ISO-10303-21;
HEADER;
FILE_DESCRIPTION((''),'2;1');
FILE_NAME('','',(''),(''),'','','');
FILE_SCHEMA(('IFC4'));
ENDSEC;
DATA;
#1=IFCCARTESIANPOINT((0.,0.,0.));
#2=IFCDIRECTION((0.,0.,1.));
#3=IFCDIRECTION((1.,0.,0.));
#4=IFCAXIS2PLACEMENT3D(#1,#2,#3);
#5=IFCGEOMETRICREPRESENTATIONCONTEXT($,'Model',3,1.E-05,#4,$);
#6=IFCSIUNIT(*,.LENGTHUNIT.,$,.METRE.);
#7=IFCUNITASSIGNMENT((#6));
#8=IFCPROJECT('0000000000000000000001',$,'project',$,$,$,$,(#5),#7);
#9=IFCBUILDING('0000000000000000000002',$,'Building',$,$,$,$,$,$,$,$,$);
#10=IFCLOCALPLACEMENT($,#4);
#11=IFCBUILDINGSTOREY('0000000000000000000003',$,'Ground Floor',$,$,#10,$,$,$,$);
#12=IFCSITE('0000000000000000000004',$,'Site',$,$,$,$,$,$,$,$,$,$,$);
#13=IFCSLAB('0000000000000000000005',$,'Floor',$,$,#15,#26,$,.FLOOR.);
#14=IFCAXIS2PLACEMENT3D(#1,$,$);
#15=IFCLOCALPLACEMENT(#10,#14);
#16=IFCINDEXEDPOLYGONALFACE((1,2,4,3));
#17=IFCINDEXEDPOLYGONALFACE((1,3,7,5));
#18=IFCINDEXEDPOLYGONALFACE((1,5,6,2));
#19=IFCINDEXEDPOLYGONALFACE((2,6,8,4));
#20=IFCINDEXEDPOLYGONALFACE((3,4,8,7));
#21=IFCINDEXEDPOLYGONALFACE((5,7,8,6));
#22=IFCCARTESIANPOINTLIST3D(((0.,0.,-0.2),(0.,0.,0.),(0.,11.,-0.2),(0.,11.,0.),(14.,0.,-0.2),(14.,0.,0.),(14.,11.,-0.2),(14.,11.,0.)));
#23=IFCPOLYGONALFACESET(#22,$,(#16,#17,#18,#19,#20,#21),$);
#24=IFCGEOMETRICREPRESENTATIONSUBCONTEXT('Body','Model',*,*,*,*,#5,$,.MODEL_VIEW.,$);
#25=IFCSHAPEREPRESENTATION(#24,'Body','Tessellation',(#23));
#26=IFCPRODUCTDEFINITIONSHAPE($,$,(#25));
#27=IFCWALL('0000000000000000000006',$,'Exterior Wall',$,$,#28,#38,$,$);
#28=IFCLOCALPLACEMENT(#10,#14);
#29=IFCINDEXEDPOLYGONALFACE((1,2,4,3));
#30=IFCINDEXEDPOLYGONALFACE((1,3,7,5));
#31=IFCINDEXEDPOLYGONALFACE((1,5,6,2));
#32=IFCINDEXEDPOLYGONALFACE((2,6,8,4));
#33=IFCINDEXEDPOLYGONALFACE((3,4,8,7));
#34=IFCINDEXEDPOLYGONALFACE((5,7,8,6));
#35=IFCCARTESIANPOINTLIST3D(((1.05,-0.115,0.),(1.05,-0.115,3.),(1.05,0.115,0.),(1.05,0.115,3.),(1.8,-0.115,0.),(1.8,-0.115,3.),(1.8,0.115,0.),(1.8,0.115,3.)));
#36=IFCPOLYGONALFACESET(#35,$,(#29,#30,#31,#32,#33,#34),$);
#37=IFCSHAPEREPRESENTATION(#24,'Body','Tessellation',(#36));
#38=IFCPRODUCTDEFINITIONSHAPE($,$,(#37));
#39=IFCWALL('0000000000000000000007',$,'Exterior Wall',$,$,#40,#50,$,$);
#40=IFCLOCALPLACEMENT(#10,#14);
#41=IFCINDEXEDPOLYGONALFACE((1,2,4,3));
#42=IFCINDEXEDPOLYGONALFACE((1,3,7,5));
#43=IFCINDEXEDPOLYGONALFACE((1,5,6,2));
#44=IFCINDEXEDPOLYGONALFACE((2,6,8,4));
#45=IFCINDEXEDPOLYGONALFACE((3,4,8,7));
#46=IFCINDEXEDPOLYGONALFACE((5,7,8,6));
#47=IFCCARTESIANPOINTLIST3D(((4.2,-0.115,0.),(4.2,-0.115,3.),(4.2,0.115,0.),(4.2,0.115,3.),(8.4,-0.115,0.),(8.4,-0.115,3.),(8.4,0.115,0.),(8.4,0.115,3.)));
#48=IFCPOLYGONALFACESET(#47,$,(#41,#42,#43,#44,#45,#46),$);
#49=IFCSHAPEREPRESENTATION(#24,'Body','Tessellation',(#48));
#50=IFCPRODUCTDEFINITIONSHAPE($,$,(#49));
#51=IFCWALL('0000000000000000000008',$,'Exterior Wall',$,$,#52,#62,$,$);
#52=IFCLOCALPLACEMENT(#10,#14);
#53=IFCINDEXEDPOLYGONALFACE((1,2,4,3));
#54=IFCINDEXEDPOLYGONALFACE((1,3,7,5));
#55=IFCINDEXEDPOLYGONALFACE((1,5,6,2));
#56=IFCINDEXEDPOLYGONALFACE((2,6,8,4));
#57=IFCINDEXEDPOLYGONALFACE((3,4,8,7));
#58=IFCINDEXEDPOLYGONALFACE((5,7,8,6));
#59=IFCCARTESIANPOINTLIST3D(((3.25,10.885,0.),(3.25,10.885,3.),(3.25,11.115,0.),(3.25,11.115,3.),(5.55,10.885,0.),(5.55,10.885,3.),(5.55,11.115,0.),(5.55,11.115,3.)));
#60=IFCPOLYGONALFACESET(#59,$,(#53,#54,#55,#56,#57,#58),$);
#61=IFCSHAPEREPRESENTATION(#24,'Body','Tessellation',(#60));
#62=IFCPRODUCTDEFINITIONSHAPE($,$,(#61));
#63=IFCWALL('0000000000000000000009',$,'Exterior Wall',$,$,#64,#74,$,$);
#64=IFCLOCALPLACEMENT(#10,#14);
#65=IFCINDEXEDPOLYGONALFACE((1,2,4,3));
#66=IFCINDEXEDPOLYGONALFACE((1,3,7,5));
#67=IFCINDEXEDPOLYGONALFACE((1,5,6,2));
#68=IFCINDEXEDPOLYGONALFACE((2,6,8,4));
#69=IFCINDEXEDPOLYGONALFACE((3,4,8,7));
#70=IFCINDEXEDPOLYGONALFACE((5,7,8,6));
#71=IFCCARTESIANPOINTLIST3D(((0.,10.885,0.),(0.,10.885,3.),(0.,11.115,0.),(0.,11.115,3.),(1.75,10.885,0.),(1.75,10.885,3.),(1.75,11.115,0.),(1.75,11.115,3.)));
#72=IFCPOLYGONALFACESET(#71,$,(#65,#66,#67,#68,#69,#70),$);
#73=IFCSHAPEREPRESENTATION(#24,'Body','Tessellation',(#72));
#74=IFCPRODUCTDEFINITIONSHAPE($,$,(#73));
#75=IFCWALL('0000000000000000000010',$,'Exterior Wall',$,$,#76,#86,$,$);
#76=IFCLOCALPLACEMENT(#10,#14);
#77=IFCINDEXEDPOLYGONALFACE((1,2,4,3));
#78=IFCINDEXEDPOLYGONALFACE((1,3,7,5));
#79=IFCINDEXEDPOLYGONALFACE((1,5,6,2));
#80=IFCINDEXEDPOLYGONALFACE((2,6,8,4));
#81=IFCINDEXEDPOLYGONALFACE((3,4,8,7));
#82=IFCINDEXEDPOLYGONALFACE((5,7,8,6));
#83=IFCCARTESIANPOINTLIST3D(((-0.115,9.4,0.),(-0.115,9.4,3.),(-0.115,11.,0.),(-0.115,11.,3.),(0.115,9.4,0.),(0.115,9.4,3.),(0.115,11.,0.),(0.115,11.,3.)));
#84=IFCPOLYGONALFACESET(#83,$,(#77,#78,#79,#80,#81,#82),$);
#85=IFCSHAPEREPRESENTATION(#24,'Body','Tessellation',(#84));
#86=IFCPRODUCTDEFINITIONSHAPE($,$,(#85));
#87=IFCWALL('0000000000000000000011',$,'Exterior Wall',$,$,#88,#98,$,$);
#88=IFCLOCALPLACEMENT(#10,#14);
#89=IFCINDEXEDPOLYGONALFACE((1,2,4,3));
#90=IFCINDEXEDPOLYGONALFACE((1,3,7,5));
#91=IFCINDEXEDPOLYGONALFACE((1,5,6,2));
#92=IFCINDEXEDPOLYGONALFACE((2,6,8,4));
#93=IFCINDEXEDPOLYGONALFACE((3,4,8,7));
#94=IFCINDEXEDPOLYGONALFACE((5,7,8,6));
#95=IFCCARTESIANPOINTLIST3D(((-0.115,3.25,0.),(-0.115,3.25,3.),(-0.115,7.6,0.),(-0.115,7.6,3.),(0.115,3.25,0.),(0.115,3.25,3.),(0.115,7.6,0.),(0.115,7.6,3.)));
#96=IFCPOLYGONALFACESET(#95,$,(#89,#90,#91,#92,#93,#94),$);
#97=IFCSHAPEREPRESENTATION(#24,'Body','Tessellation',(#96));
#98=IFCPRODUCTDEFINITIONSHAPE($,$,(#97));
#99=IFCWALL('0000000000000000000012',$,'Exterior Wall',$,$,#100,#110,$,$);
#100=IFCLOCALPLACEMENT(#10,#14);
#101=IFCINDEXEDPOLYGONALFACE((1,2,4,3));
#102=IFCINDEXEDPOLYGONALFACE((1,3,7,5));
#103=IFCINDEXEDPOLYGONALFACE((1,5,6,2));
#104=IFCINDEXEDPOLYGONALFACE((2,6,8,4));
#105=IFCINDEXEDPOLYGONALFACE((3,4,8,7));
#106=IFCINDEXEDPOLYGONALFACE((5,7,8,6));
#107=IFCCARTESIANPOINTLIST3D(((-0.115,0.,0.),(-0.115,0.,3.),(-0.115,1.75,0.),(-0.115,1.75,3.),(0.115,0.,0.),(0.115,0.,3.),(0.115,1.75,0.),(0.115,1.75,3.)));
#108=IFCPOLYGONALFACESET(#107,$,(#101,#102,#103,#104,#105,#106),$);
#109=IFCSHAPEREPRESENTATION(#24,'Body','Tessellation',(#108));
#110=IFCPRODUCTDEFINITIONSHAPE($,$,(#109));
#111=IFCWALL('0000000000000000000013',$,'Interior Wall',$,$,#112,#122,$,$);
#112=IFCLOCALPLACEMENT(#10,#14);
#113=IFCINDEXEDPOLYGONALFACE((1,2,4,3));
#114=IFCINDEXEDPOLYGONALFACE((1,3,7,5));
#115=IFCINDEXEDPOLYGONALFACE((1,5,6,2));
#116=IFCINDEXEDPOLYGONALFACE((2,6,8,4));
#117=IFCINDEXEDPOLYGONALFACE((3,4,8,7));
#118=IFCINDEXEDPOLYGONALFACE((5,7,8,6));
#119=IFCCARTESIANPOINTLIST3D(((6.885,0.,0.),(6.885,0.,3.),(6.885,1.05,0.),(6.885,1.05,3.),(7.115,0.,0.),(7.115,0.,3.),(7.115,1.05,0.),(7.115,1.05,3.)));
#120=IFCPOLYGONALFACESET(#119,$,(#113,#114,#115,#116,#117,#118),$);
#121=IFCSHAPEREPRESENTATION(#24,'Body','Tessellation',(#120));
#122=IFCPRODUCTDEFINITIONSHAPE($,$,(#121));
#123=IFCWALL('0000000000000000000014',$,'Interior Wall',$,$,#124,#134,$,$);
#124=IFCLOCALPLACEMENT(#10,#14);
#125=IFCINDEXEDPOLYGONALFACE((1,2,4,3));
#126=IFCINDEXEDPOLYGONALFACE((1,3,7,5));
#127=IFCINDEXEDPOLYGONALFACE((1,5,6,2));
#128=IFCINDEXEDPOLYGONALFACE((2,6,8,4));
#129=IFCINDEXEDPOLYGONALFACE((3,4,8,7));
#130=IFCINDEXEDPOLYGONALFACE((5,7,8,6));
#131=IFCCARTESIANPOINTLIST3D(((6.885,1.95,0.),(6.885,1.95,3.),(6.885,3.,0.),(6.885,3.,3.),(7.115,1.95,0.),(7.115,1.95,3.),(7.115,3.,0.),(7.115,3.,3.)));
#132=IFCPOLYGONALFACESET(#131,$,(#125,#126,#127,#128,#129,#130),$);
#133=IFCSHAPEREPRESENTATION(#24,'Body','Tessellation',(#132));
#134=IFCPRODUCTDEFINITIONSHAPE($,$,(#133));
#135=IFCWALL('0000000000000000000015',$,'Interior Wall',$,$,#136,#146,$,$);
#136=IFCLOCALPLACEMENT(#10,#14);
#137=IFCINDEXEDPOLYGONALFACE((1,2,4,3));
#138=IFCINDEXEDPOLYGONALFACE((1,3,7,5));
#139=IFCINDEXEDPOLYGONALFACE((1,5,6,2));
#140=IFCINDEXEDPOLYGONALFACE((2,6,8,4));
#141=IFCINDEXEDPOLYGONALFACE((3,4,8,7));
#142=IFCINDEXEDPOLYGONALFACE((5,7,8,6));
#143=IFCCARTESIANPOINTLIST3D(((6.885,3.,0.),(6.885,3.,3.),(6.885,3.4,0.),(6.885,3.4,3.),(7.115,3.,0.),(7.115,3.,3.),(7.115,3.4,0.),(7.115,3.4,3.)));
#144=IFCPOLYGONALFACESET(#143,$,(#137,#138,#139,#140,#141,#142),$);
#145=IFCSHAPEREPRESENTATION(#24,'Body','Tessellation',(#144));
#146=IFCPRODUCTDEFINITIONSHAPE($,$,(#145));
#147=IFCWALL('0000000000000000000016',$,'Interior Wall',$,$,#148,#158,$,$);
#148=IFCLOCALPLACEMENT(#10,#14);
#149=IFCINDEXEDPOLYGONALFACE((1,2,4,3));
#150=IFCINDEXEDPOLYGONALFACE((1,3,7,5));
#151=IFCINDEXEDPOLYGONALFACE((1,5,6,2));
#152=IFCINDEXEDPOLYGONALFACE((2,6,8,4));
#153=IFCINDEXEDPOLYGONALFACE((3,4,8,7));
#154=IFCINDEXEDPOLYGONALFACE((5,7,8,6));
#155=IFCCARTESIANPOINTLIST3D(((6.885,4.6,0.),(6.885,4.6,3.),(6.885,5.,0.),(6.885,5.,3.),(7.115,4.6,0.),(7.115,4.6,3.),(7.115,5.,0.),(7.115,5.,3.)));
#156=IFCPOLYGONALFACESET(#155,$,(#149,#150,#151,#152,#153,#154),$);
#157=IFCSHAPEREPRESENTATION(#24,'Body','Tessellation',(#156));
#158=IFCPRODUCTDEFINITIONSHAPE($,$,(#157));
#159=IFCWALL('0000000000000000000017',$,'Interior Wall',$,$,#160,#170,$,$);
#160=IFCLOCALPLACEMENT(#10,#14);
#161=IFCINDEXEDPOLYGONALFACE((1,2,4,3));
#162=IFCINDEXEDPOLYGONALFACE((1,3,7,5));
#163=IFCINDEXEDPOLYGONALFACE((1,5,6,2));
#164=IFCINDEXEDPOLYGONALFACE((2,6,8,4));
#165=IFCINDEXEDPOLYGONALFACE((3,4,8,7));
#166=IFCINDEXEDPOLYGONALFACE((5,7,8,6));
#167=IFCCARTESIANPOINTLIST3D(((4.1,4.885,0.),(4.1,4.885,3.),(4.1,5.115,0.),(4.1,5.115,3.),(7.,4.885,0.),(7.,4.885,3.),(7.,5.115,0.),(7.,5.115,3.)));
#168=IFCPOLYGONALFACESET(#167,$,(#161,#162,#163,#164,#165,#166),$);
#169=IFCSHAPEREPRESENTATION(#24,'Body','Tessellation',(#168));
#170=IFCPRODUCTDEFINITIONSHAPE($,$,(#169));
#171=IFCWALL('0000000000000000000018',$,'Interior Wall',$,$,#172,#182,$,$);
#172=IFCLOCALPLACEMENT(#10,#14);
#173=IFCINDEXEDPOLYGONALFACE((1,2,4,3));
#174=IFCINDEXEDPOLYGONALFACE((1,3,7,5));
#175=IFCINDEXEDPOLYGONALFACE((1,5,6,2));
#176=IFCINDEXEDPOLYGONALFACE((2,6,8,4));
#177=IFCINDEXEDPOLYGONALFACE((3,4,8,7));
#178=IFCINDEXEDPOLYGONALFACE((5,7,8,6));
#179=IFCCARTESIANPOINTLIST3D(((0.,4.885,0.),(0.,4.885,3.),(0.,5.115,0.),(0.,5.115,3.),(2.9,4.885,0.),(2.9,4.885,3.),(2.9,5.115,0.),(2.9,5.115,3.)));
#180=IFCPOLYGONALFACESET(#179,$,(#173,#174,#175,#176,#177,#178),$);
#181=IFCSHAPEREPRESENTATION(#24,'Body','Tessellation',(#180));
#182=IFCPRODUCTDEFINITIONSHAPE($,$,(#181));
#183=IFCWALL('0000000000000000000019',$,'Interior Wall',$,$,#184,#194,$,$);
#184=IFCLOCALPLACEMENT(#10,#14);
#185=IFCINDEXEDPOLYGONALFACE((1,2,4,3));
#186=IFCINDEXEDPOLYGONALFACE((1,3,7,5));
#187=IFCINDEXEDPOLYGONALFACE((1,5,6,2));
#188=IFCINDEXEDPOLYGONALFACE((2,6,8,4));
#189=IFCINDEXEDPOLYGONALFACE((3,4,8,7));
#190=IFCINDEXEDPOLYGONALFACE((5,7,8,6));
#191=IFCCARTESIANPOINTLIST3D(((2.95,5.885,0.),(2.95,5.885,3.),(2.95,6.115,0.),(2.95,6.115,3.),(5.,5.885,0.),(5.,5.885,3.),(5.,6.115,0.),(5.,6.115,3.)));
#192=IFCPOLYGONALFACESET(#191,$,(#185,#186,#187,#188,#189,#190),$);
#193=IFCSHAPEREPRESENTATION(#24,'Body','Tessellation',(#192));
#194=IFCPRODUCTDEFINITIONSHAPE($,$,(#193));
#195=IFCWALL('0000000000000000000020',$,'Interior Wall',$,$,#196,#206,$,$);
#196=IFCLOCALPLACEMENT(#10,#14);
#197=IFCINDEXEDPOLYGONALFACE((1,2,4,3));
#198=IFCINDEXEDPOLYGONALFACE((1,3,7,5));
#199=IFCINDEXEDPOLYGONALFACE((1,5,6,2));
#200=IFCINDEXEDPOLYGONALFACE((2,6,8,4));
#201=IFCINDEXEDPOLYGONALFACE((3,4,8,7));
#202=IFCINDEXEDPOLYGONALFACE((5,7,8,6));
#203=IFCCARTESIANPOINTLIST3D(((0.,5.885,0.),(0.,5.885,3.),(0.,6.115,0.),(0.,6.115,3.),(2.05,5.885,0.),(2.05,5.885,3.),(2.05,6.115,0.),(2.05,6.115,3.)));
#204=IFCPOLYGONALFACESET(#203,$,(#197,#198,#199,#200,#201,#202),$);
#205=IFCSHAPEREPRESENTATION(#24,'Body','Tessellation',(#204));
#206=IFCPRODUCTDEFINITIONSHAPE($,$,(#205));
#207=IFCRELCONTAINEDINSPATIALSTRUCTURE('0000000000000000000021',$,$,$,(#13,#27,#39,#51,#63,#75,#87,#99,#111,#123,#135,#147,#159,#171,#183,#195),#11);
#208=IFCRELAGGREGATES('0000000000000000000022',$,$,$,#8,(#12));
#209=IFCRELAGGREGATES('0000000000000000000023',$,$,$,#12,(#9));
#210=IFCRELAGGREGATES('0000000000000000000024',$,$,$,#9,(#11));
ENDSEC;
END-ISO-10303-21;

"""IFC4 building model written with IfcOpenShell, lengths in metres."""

from ifc_helpers import new_model, si_unit, frame, origin_with_axes, place, context, subcontext, project, spatial, indexed_curve, outline, extrude, element, save


model = new_model("IFC4")

# Units and contexts
model_context = context("Model", 3, precision=1e-05, world=origin_with_axes())
body_context = subcontext(model_context, "Body", "Model", "MODEL_VIEW")
ifc_project = project(units=[si_unit("LENGTHUNIT", "METRE")], contexts=[model_context])

# Site, building, storey
site = spatial("IfcSite", under=ifc_project, Name="Site")
building = spatial("IfcBuilding", under=site, Name="Building")
storey_placement = place(None, origin_with_axes())
storey = spatial("IfcBuildingStorey", under=building, at=storey_placement, Name="Ground Floor")

# Slab
slab_placement = place(storey_placement, frame((0.0, 0.0, -0.2), z_axis=(0.0, 0.0, 1.0), x_axis=(1.0, 0.0, 0.0)))
element("IfcSlab", 1, at=slab_placement, inside=storey, Name="Floor", PredefinedType="FLOOR", context=body_context, shape_type="SweptSolid", body=[
    extrude(outline(indexed_curve([(0.0, 0.0), (14.0, 0.0), (14.0, 11.0), (0.0, 11.0)])), None, (0.0, 0.0, 1.0), 0.2),
])

# Walls
wall_1_placement = place(storey_placement, frame((1.05, 0.0, 0.0), z_axis=(0.0, 0.0, 1.0), x_axis=(1.0, 0.0, 0.0)))
element("IfcWall", 2, at=wall_1_placement, inside=storey, Name="Exterior Wall", context=body_context, shape_type="SweptSolid", body=[
    extrude(outline(indexed_curve([(0.0, 0.0), (0.0, 0.23), (0.75, 0.23), (0.75, 0.0), (0.0, 0.0)], self_intersect=False)), frame((0.0, -0.115, 0.0), z_axis=(0.0, 0.0, 1.0), x_axis=(1.0, 0.0, 0.0)), (0.0, 0.0, 1.0), 3.0),
])
wall_2_placement = place(storey_placement, frame((4.2, 0.0, 0.0), z_axis=(0.0, 0.0, 1.0), x_axis=(1.0, 0.0, 0.0)))
element("IfcWall", 3, at=wall_2_placement, inside=storey, Name="Exterior Wall", context=body_context, shape_type="SweptSolid", body=[
    extrude(outline(indexed_curve([(0.0, 0.0), (0.0, 0.23), (4.2, 0.23), (4.2, 0.0), (0.0, 0.0)], self_intersect=False)), frame((0.0, -0.115, 0.0), z_axis=(0.0, 0.0, 1.0), x_axis=(1.0, 0.0, 0.0)), (0.0, 0.0, 1.0), 3.0),
])
wall_3_placement = place(storey_placement, frame((5.55, 11.0, 0.0), z_axis=(0.0, 0.0, 1.0), x_axis=(-1.0, 0.0, 0.0)))
element("IfcWall", 4, at=wall_3_placement, inside=storey, Name="Exterior Wall", context=body_context, shape_type="SweptSolid", body=[
    extrude(outline(indexed_curve([(0.0, 0.0), (0.0, 0.23), (2.3, 0.23), (2.3, 0.0), (0.0, 0.0)], self_intersect=False)), frame((0.0, -0.115, 0.0), z_axis=(0.0, 0.0, 1.0), x_axis=(1.0, 0.0, 0.0)), (0.0, 0.0, 1.0), 3.0),
])
wall_4_placement = place(storey_placement, frame((1.75, 11.0, 0.0), z_axis=(0.0, 0.0, 1.0), x_axis=(-1.0, 0.0, 0.0)))
element("IfcWall", 5, at=wall_4_placement, inside=storey, Name="Exterior Wall", context=body_context, shape_type="SweptSolid", body=[
    extrude(outline(indexed_curve([(0.0, 0.0), (0.0, 0.23), (1.75, 0.23), (1.75, 0.0), (0.0, 0.0)], self_intersect=False)), frame((0.0, -0.115, 0.0), z_axis=(0.0, 0.0, 1.0), x_axis=(1.0, 0.0, 0.0)), (0.0, 0.0, 1.0), 3.0),
])
wall_5_placement = place(storey_placement, frame((0.0, 11.0, 0.0), z_axis=(0.0, 0.0, 1.0), x_axis=(0.0, -1.0, 0.0)))
element("IfcWall", 6, at=wall_5_placement, inside=storey, Name="Exterior Wall", context=body_context, shape_type="SweptSolid", body=[
    extrude(outline(indexed_curve([(0.0, 0.0), (0.0, 0.23), (1.6, 0.23), (1.6, 0.0), (0.0, 0.0)], self_intersect=False)), frame((0.0, -0.115, 0.0), z_axis=(0.0, 0.0, 1.0), x_axis=(1.0, 0.0, 0.0)), (0.0, 0.0, 1.0), 3.0),
])
wall_6_placement = place(storey_placement, frame((0.0, 7.6, 0.0), z_axis=(0.0, 0.0, 1.0), x_axis=(0.0, -1.0, 0.0)))
element("IfcWall", 7, at=wall_6_placement, inside=storey, Name="Exterior Wall", context=body_context, shape_type="SweptSolid", body=[
    extrude(outline(indexed_curve([(0.0, 0.0), (0.0, 0.23), (4.35, 0.23), (4.35, 0.0), (0.0, 0.0)], self_intersect=False)), frame((0.0, -0.115, 0.0), z_axis=(0.0, 0.0, 1.0), x_axis=(1.0, 0.0, 0.0)), (0.0, 0.0, 1.0), 3.0),
])
wall_7_placement = place(storey_placement, frame((0.0, 1.75, 0.0), z_axis=(0.0, 0.0, 1.0), x_axis=(0.0, -1.0, 0.0)))
element("IfcWall", 8, at=wall_7_placement, inside=storey, Name="Exterior Wall", context=body_context, shape_type="SweptSolid", body=[
    extrude(outline(indexed_curve([(0.0, 0.0), (0.0, 0.23), (1.75, 0.23), (1.75, 0.0), (0.0, 0.0)], self_intersect=False)), frame((0.0, -0.115, 0.0), z_axis=(0.0, 0.0, 1.0), x_axis=(1.0, 0.0, 0.0)), (0.0, 0.0, 1.0), 3.0),
])
for number, where, z_axis, x_axis, name in (
    (9, (7.0, 0.0, 0.0), (0.0, 0.0, 1.0), (0.0, 1.0, 0.0), "Interior Wall"),
    (10, (7.0, 1.95, 0.0), (0.0, 0.0, 1.0), (0.0, 1.0, 0.0), "Interior Wall"),
):
    element("IfcWall", number, at=place(storey_placement, frame(where, z_axis=z_axis, x_axis=x_axis)), inside=storey, Name=name, context=body_context, shape_type="SweptSolid", body=[
        extrude(outline(indexed_curve([(0.0, 0.0), (0.0, 0.23), (1.05, 0.23), (1.05, 0.0), (0.0, 0.0)], self_intersect=False)), frame((0.0, -0.115, 0.0), z_axis=(0.0, 0.0, 1.0), x_axis=(1.0, 0.0, 0.0)), (0.0, 0.0, 1.0), 3.0),
    ])
wall_8_placement = place(storey_placement, frame((7.0, 3.0, 0.0), z_axis=(0.0, 0.0, 1.0), x_axis=(0.0, 1.0, 0.0)))
element("IfcWall", 11, at=wall_8_placement, inside=storey, Name="Interior Wall", context=body_context, shape_type="SweptSolid", body=[
    extrude(outline(indexed_curve([(0.0, 0.0), (0.0, 0.23), (0.4, 0.23), (0.4, 0.0), (0.0, 0.0)], self_intersect=False)), frame((0.0, -0.115, 0.0), z_axis=(0.0, 0.0, 1.0), x_axis=(1.0, 0.0, 0.0)), (0.0, 0.0, 1.0), 3.0),
])
wall_9_placement = place(storey_placement, frame((7.0, 4.6, 0.0), z_axis=(0.0, 0.0, 1.0), x_axis=(0.0, 1.0, 0.0)))
element("IfcWall", 12, at=wall_9_placement, inside=storey, Name="Interior Wall", context=body_context, shape_type="SweptSolid", body=[
    extrude(outline(indexed_curve([(0.0, 0.0), (0.0, 0.23), (0.4, 0.23), (0.4, 0.0), (0.0, 0.0)], self_intersect=False)), frame((0.0, -0.115, 0.0), z_axis=(0.0, 0.0, 1.0), x_axis=(1.0, 0.0, 0.0)), (0.0, 0.0, 1.0), 3.0),
])
for number, where, z_axis, x_axis, name in (
    (13, (7.0, 5.0, 0.0), (0.0, 0.0, 1.0), (-1.0, 0.0, 0.0), "Interior Wall"),
    (14, (2.9, 5.0, 0.0), (0.0, 0.0, 1.0), (-1.0, 0.0, 0.0), "Interior Wall"),
):
    element("IfcWall", number, at=place(storey_placement, frame(where, z_axis=z_axis, x_axis=x_axis)), inside=storey, Name=name, context=body_context, shape_type="SweptSolid", body=[
        extrude(outline(indexed_curve([(0.0, 0.0), (0.0, 0.23), (2.9, 0.23), (2.9, 0.0), (0.0, 0.0)], self_intersect=False)), frame((0.0, -0.115, 0.0), z_axis=(0.0, 0.0, 1.0), x_axis=(1.0, 0.0, 0.0)), (0.0, 0.0, 1.0), 3.0),
    ])
for number, where, z_axis, x_axis, name in (
    (15, (5.0, 6.0, 0.0), (0.0, 0.0, 1.0), (-1.0, 0.0, 0.0), "Interior Wall"),
    (16, (2.05, 6.0, 0.0), (0.0, 0.0, 1.0), (-1.0, 0.0, 0.0), "Interior Wall"),
):
    element("IfcWall", number, at=place(storey_placement, frame(where, z_axis=z_axis, x_axis=x_axis)), inside=storey, Name=name, context=body_context, shape_type="SweptSolid", body=[
        extrude(outline(indexed_curve([(0.0, 0.0), (0.0, 0.23), (2.05, 0.23), (2.05, 0.0), (0.0, 0.0)], self_intersect=False)), frame((0.0, -0.115, 0.0), z_axis=(0.0, 0.0, 1.0), x_axis=(1.0, 0.0, 0.0)), (0.0, 0.0, 1.0), 3.0),
    ])

save(model, "model.ifc")
